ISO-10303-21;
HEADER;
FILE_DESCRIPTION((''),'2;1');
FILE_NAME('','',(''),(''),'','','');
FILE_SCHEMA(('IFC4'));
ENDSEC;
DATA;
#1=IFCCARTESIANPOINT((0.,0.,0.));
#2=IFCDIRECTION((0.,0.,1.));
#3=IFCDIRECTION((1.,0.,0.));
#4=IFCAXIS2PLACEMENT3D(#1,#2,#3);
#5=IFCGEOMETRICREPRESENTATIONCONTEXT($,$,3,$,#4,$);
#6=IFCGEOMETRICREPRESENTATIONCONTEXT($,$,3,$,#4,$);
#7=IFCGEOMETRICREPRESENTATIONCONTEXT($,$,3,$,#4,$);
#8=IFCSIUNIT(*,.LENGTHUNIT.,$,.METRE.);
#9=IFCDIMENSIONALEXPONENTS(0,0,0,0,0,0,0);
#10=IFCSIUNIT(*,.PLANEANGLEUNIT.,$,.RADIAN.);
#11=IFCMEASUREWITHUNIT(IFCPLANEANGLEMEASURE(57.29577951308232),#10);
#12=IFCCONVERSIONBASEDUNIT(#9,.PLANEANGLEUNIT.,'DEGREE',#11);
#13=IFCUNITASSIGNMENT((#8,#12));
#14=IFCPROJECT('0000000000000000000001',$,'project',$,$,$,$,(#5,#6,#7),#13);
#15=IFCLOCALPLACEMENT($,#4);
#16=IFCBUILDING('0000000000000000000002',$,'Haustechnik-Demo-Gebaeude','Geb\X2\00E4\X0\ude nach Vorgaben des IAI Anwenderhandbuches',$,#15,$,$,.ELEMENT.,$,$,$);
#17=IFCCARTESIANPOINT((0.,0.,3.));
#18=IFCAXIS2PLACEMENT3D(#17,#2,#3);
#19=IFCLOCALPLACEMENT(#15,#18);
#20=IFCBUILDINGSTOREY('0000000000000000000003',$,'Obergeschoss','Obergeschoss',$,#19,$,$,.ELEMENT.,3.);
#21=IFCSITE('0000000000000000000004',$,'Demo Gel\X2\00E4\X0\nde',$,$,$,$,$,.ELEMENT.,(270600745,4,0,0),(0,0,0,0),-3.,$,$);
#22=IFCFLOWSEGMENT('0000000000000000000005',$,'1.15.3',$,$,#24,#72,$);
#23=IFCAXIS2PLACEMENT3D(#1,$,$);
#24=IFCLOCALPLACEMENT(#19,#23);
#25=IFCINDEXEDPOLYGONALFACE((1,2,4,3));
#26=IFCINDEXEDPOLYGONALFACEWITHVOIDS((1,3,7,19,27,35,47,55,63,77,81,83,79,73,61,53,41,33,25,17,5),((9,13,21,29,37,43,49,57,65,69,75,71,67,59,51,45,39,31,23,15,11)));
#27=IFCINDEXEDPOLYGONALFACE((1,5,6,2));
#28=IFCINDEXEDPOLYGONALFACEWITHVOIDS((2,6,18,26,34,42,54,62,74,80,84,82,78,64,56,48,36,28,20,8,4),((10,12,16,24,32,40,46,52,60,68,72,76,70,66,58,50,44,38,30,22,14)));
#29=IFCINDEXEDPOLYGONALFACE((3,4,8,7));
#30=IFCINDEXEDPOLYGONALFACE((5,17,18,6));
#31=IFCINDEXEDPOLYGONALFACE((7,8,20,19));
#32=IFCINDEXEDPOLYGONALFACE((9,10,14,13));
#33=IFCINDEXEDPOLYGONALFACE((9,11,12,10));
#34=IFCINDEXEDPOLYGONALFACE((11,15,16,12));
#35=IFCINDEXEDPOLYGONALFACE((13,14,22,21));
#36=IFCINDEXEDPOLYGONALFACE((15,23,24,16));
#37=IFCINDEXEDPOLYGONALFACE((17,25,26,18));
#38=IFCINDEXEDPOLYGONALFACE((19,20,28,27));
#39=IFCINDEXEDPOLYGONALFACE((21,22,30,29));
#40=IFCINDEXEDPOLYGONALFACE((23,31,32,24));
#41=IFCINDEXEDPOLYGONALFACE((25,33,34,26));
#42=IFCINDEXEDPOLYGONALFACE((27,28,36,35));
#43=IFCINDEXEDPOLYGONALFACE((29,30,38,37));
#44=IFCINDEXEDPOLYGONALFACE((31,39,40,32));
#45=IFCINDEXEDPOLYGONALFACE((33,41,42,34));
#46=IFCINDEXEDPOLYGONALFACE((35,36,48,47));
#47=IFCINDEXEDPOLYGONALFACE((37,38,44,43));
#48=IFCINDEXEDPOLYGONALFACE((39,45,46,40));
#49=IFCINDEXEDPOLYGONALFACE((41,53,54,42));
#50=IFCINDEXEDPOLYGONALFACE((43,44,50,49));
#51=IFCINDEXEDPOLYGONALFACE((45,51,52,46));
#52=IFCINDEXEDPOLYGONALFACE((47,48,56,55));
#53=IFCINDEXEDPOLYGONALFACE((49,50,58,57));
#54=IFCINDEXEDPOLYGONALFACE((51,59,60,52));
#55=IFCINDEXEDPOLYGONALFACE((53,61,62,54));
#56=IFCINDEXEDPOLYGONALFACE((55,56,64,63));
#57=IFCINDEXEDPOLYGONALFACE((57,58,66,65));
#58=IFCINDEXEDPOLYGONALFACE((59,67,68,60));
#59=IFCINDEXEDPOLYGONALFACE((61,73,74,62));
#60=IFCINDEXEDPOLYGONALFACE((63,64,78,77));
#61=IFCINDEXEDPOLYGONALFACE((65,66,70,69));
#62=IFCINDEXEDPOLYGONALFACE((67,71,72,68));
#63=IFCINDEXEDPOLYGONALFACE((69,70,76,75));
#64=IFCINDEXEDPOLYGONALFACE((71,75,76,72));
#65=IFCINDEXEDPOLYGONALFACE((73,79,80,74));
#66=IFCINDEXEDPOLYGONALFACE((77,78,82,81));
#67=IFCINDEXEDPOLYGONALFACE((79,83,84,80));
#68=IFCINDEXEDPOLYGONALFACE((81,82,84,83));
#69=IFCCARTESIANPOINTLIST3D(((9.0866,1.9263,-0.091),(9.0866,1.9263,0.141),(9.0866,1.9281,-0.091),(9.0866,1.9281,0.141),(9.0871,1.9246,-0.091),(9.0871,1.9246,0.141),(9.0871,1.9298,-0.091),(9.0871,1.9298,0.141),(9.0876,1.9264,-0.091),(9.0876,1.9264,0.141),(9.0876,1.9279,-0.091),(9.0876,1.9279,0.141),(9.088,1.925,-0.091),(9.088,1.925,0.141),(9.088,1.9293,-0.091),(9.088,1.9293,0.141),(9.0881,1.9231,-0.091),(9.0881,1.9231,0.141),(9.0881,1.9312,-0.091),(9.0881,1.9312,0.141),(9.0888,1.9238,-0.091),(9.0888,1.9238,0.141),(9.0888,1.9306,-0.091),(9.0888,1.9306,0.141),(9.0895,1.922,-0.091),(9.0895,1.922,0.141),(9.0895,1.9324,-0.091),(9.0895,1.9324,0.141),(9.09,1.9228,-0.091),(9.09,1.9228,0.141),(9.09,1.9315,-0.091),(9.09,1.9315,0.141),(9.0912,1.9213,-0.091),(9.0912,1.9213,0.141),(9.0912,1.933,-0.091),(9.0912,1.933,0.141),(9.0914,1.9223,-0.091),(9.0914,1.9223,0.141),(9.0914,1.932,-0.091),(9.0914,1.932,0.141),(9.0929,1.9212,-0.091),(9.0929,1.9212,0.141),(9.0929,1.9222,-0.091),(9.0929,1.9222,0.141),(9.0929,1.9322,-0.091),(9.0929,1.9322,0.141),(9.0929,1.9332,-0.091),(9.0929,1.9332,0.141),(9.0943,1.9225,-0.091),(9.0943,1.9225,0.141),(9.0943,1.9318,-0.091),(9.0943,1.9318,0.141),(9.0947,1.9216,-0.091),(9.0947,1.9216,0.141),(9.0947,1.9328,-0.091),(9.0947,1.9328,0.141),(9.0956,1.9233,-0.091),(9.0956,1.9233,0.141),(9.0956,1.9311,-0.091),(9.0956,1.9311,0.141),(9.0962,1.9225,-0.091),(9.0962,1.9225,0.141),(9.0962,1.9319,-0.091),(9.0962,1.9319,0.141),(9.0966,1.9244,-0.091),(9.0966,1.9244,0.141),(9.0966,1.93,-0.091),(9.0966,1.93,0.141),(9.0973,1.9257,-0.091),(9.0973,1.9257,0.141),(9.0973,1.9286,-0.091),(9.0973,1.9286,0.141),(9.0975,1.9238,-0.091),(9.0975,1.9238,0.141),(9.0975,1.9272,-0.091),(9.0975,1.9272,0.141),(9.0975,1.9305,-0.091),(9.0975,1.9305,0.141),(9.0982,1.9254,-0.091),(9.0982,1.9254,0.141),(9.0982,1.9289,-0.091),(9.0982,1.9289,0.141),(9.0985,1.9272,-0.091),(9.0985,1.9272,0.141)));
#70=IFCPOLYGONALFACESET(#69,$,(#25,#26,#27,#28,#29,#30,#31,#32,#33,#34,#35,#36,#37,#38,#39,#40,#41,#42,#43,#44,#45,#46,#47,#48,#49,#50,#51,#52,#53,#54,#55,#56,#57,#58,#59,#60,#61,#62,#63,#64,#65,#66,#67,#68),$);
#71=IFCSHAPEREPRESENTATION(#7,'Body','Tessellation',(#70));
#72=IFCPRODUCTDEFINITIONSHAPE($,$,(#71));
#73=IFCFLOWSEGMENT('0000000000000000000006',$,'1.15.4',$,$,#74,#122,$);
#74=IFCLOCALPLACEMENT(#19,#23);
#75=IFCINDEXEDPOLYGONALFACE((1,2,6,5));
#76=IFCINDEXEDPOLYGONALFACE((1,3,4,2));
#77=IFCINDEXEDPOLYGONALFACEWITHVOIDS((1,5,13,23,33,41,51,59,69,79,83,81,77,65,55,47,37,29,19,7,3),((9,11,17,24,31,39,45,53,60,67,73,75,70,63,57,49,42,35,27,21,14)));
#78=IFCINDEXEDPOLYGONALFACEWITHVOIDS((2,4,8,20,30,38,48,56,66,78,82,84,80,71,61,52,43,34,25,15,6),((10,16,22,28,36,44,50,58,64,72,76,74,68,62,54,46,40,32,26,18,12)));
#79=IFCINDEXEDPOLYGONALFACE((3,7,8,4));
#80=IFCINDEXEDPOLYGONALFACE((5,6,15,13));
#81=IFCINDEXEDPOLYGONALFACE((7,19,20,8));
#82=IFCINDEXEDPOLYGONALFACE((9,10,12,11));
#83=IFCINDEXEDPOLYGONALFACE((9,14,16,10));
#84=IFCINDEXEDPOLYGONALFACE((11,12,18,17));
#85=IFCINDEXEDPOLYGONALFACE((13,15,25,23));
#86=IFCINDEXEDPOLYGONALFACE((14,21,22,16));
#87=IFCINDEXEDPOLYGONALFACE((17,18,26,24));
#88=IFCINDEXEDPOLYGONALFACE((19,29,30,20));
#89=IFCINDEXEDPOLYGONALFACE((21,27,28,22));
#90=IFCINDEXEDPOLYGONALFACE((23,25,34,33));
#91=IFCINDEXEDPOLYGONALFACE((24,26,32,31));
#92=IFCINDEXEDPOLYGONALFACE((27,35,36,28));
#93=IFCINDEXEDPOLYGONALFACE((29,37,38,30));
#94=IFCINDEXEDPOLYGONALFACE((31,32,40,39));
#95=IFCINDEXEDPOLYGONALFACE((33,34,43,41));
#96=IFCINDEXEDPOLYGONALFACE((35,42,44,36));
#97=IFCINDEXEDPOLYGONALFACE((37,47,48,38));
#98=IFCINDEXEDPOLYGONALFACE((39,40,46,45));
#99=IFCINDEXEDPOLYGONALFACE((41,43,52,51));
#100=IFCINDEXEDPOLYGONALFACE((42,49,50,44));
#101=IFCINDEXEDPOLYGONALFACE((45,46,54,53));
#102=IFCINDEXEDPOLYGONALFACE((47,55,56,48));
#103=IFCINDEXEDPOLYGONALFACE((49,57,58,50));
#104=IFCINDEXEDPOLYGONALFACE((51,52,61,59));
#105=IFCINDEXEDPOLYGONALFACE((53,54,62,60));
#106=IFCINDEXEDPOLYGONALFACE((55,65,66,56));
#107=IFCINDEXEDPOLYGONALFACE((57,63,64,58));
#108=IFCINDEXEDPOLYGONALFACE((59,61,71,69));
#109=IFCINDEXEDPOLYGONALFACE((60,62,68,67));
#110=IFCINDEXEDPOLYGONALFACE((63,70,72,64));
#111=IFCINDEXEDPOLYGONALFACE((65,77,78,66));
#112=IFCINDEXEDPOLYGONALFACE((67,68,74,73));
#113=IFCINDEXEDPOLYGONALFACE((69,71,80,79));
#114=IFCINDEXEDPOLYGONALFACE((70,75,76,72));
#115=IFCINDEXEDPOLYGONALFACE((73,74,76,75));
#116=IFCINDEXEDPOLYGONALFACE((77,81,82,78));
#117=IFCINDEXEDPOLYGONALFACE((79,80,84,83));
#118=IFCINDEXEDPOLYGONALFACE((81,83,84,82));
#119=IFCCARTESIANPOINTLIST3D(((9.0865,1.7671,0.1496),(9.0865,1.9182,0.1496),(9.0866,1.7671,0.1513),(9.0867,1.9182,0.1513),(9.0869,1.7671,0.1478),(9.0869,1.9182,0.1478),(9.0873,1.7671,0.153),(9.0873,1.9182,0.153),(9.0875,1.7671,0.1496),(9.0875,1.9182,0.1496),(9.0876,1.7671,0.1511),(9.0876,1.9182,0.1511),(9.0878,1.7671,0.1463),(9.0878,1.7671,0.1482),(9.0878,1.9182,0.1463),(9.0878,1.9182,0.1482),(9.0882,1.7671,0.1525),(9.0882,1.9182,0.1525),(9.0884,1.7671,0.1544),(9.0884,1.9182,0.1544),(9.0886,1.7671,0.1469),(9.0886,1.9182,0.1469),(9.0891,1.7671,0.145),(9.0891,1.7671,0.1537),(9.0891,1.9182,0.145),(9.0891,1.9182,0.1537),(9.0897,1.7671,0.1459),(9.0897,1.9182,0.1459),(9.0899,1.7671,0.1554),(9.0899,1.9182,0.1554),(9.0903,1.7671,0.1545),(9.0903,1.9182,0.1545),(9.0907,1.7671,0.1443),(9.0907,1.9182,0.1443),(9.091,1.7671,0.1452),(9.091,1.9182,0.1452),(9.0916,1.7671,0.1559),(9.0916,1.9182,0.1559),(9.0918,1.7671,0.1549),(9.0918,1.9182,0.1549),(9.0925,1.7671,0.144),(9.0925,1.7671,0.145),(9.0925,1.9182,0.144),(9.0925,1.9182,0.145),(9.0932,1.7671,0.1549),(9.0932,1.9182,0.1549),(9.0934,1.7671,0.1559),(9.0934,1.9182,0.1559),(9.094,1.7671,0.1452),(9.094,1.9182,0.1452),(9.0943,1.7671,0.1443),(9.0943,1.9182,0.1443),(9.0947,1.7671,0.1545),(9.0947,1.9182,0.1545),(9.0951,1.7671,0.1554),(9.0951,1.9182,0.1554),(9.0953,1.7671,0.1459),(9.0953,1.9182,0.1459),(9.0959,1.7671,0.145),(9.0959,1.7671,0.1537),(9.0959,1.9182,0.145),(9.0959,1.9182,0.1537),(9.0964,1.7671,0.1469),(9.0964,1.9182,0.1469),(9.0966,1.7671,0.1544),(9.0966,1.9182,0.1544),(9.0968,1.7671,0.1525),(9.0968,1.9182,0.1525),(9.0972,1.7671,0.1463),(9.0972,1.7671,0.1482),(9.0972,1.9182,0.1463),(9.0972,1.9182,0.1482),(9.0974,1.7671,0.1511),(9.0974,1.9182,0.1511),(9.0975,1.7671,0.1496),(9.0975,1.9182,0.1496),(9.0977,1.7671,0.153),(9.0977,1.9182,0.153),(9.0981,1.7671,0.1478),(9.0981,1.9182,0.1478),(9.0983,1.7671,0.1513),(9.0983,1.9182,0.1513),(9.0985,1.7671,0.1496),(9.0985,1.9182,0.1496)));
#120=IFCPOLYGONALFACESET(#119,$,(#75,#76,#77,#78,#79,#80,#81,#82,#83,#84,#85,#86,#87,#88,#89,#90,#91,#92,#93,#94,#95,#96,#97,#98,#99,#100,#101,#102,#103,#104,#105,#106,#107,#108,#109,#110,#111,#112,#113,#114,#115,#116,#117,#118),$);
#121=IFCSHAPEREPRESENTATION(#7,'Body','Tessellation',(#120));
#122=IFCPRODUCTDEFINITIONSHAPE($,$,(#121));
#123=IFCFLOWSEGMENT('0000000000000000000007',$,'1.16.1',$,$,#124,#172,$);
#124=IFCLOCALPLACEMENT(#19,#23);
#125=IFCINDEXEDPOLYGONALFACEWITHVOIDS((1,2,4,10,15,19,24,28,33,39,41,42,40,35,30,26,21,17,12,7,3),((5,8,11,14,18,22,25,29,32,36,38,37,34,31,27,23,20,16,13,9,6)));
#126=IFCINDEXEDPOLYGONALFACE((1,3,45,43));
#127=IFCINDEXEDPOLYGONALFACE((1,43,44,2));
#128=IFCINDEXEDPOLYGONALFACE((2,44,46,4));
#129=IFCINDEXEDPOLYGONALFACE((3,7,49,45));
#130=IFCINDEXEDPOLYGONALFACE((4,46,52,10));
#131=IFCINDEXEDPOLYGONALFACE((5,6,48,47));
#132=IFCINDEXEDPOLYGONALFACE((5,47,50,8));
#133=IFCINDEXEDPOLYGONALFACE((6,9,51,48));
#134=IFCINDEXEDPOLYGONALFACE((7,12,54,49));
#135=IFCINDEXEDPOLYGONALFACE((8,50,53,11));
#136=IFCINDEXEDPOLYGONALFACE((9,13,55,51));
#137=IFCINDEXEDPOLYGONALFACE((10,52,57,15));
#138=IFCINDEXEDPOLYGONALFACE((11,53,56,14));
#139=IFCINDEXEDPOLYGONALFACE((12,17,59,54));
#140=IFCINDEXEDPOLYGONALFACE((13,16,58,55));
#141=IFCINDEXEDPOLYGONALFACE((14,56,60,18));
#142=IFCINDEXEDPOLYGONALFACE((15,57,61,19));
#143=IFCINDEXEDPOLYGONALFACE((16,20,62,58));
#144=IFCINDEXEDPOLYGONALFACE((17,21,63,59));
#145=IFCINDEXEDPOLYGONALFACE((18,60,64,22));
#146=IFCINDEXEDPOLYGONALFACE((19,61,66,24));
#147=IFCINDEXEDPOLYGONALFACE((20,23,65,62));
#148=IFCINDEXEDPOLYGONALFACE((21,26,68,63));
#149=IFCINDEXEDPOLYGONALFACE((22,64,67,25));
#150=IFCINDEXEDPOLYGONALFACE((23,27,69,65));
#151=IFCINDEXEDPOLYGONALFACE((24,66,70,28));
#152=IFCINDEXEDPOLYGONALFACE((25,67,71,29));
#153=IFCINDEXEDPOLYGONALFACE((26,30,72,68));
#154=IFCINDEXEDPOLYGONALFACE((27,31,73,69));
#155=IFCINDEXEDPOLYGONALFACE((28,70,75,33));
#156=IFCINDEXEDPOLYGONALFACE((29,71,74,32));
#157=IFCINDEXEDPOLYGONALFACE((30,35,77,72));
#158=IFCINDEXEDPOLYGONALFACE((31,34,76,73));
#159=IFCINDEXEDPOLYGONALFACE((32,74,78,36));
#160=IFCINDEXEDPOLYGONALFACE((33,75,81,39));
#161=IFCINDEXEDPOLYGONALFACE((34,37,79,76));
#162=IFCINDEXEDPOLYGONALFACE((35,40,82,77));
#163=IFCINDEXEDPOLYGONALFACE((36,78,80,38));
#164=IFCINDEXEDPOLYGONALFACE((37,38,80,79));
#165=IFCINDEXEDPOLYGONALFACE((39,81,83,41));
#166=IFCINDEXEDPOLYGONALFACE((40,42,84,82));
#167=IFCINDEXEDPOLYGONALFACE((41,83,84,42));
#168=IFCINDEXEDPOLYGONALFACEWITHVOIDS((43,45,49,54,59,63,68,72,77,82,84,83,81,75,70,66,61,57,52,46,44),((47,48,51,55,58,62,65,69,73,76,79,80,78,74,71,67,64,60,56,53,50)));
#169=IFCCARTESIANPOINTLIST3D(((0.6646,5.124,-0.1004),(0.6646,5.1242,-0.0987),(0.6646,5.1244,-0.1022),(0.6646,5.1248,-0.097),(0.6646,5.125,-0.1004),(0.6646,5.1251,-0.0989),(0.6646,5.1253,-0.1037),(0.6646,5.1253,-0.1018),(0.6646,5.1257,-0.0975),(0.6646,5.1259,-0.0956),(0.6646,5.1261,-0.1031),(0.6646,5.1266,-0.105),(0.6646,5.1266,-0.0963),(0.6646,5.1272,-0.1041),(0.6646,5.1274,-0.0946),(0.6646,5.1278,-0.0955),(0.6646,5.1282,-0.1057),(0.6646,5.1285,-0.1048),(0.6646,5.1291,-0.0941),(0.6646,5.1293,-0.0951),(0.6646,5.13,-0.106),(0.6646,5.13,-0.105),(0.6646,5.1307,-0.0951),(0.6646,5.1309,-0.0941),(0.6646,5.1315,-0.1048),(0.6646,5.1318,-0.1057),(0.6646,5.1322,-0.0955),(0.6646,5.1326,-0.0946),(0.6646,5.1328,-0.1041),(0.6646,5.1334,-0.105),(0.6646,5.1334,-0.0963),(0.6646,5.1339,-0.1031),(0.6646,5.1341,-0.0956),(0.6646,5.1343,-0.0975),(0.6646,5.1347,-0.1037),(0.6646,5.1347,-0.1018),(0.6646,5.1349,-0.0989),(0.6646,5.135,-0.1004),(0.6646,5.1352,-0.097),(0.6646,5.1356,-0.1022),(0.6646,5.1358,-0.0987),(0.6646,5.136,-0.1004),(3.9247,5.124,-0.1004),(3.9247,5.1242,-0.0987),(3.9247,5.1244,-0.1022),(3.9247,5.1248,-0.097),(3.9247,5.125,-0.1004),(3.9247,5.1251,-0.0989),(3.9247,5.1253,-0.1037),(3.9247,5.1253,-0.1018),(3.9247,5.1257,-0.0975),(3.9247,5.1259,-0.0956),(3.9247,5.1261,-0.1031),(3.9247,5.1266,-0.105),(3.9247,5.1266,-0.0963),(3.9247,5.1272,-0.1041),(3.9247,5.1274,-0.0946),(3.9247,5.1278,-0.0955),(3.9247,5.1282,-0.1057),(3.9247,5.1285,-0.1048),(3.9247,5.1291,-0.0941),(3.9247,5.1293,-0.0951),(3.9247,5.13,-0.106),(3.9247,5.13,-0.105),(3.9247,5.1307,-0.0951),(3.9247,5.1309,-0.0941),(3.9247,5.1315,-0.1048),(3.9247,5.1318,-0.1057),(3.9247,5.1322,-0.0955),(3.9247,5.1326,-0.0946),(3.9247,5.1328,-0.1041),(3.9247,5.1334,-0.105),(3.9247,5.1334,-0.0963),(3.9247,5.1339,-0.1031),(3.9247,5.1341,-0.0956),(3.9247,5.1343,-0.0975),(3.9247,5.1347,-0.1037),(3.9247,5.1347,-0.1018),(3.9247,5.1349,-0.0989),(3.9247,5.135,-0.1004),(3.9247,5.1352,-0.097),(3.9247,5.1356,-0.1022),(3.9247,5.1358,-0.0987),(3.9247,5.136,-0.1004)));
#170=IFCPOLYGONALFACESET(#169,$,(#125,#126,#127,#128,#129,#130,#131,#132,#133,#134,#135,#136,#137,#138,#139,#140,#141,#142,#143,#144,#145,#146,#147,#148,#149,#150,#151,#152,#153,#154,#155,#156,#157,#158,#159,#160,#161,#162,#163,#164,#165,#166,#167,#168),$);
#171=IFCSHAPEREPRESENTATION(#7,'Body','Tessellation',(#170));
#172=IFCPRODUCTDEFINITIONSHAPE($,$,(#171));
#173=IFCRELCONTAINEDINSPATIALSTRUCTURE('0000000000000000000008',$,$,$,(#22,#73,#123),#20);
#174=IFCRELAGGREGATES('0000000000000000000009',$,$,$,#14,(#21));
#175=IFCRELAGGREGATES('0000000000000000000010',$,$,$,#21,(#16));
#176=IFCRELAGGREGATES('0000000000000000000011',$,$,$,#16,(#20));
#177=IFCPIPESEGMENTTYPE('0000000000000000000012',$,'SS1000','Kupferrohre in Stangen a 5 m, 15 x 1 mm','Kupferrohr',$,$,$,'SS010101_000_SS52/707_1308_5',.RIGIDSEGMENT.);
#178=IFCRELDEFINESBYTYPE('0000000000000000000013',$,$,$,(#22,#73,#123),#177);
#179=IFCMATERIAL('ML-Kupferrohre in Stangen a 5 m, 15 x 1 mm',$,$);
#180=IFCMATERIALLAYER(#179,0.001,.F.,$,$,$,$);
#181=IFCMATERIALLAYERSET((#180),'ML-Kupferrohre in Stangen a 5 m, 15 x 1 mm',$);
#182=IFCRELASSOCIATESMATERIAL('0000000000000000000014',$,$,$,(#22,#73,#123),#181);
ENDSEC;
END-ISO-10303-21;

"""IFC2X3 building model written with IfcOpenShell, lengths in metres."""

from ifc_helpers import new_model, entity, si_unit, converted_unit, frame, origin_with_axes, origin_2d_with_axis, place, context, project, spatial, hollow_circle, extrude, material, layer, layer_set, layer_usage, type_object, element, save


model = new_model("IFC2X3")

# Units and contexts
context_of_model_1 = context(None, 3, world=origin_with_axes())
context_of_model_2 = context(None, 3, world=origin_with_axes())
context_of_model_3 = context(None, 3, world=origin_with_axes())
ifc_project = project(units=[si_unit("LENGTHUNIT", "METRE"), converted_unit("PLANEANGLEUNIT", "DEGREE", entity("IfcPlaneAngleMeasure", 57.29577951308232), si_unit("PLANEANGLEUNIT", "RADIAN"), dimensions=[0, 0, 0, 0, 0, 0, 0])], contexts=[context_of_model_1, context_of_model_2, context_of_model_3])

# Site, building, storey
site = spatial("IfcSite", under=ifc_project, Name="Demo Gelände", CompositionType="ELEMENT", RefLatitude=(270600745, 4, 0, 0), RefLongitude=(0, 0, 0, 0), RefElevation=-3.0)
building_placement = place(None, origin_with_axes())
building = spatial("IfcBuilding", under=site, at=building_placement, Name="Haustechnik-Demo-Gebaeude", Description="Gebäude nach Vorgaben des IAI Anwenderhandbuches", CompositionType="ELEMENT")
storey_placement = place(building_placement, frame((0.0, 0.0, 3.0), z_axis=(0.0, 0.0, 1.0), x_axis=(1.0, 0.0, 0.0)))
storey = spatial("IfcBuildingStorey", under=building, at=storey_placement, Name="Obergeschoss", Description="Obergeschoss", CompositionType="ELEMENT", Elevation=3.0)

# Flow segments
ifc_material = material(Name="ML-Kupferrohre in Stangen a 5 m, 15 x 1 mm")
ifc_layer = layer(ifc_material, 0.001, ventilated=False)
ifc_layer_set = layer_set([ifc_layer], Name="ML-Kupferrohre in Stangen a 5 m, 15 x 1 mm")
ifc_layer_usage = layer_usage(ifc_layer_set, "AXIS2", "POSITIVE", 0.0)
pipe_segment_type_1 = type_object("IfcPipeSegmentType", Name="SS1000", Description="Kupferrohre in Stangen a 5 m, 15 x 1 mm", ApplicableOccurrence="Kupferrohr", ElementType="SS010101_000_SS52/707_1308_5", PredefinedType="RIGIDSEGMENT")
flow_segment_1_placement = place(storey_placement, frame((9.0925, 1.9272, -0.091), z_axis=(0.0, 0.0, 1.0), x_axis=(1.0, 0.0, 0.0)))
element("IfcFlowSegment", 1, at=flow_segment_1_placement, inside=storey, type_object=pipe_segment_type_1, material=ifc_layer_usage, Name="1.15.3", context=context_of_model_3, shape_type="SweptSolid", body=[
    extrude(hollow_circle(Radius=0.006, WallThickness=0.001, at=origin_2d_with_axis()), origin_with_axes(), (0.0, 0.0, 1.0), 0.232),
])
flow_segment_2_placement = place(storey_placement, frame((9.0925, 1.9182, 0.15), z_axis=(-0.000001, -1.0, 0.0), x_axis=(0.0, 0.0, -1.0)))
element("IfcFlowSegment", 2, at=flow_segment_2_placement, inside=storey, type_object=pipe_segment_type_1, material=ifc_layer_usage, Name="1.15.4", context=context_of_model_3, shape_type="SweptSolid", body=[
    extrude(hollow_circle(Radius=0.006, WallThickness=0.001, at=origin_2d_with_axis()), origin_with_axes(), (0.0, 0.0, 1.0), 0.151),
])
flow_segment_3_placement = place(storey_placement, frame((3.9247, 5.13, -0.1), z_axis=(-1.0, 0.0, 0.0), x_axis=(0.0, 0.0, -1.0)))
element("IfcFlowSegment", 3, at=flow_segment_3_placement, inside=storey, type_object=pipe_segment_type_1, material=ifc_layer_usage, Name="1.16.1", context=context_of_model_3, shape_type="SweptSolid", body=[
    extrude(hollow_circle(Radius=0.006, WallThickness=0.001, at=origin_2d_with_axis()), origin_with_axes(), (0.0, 0.0, 1.0), 3.2601),
])

save(model, "model.ifc")
